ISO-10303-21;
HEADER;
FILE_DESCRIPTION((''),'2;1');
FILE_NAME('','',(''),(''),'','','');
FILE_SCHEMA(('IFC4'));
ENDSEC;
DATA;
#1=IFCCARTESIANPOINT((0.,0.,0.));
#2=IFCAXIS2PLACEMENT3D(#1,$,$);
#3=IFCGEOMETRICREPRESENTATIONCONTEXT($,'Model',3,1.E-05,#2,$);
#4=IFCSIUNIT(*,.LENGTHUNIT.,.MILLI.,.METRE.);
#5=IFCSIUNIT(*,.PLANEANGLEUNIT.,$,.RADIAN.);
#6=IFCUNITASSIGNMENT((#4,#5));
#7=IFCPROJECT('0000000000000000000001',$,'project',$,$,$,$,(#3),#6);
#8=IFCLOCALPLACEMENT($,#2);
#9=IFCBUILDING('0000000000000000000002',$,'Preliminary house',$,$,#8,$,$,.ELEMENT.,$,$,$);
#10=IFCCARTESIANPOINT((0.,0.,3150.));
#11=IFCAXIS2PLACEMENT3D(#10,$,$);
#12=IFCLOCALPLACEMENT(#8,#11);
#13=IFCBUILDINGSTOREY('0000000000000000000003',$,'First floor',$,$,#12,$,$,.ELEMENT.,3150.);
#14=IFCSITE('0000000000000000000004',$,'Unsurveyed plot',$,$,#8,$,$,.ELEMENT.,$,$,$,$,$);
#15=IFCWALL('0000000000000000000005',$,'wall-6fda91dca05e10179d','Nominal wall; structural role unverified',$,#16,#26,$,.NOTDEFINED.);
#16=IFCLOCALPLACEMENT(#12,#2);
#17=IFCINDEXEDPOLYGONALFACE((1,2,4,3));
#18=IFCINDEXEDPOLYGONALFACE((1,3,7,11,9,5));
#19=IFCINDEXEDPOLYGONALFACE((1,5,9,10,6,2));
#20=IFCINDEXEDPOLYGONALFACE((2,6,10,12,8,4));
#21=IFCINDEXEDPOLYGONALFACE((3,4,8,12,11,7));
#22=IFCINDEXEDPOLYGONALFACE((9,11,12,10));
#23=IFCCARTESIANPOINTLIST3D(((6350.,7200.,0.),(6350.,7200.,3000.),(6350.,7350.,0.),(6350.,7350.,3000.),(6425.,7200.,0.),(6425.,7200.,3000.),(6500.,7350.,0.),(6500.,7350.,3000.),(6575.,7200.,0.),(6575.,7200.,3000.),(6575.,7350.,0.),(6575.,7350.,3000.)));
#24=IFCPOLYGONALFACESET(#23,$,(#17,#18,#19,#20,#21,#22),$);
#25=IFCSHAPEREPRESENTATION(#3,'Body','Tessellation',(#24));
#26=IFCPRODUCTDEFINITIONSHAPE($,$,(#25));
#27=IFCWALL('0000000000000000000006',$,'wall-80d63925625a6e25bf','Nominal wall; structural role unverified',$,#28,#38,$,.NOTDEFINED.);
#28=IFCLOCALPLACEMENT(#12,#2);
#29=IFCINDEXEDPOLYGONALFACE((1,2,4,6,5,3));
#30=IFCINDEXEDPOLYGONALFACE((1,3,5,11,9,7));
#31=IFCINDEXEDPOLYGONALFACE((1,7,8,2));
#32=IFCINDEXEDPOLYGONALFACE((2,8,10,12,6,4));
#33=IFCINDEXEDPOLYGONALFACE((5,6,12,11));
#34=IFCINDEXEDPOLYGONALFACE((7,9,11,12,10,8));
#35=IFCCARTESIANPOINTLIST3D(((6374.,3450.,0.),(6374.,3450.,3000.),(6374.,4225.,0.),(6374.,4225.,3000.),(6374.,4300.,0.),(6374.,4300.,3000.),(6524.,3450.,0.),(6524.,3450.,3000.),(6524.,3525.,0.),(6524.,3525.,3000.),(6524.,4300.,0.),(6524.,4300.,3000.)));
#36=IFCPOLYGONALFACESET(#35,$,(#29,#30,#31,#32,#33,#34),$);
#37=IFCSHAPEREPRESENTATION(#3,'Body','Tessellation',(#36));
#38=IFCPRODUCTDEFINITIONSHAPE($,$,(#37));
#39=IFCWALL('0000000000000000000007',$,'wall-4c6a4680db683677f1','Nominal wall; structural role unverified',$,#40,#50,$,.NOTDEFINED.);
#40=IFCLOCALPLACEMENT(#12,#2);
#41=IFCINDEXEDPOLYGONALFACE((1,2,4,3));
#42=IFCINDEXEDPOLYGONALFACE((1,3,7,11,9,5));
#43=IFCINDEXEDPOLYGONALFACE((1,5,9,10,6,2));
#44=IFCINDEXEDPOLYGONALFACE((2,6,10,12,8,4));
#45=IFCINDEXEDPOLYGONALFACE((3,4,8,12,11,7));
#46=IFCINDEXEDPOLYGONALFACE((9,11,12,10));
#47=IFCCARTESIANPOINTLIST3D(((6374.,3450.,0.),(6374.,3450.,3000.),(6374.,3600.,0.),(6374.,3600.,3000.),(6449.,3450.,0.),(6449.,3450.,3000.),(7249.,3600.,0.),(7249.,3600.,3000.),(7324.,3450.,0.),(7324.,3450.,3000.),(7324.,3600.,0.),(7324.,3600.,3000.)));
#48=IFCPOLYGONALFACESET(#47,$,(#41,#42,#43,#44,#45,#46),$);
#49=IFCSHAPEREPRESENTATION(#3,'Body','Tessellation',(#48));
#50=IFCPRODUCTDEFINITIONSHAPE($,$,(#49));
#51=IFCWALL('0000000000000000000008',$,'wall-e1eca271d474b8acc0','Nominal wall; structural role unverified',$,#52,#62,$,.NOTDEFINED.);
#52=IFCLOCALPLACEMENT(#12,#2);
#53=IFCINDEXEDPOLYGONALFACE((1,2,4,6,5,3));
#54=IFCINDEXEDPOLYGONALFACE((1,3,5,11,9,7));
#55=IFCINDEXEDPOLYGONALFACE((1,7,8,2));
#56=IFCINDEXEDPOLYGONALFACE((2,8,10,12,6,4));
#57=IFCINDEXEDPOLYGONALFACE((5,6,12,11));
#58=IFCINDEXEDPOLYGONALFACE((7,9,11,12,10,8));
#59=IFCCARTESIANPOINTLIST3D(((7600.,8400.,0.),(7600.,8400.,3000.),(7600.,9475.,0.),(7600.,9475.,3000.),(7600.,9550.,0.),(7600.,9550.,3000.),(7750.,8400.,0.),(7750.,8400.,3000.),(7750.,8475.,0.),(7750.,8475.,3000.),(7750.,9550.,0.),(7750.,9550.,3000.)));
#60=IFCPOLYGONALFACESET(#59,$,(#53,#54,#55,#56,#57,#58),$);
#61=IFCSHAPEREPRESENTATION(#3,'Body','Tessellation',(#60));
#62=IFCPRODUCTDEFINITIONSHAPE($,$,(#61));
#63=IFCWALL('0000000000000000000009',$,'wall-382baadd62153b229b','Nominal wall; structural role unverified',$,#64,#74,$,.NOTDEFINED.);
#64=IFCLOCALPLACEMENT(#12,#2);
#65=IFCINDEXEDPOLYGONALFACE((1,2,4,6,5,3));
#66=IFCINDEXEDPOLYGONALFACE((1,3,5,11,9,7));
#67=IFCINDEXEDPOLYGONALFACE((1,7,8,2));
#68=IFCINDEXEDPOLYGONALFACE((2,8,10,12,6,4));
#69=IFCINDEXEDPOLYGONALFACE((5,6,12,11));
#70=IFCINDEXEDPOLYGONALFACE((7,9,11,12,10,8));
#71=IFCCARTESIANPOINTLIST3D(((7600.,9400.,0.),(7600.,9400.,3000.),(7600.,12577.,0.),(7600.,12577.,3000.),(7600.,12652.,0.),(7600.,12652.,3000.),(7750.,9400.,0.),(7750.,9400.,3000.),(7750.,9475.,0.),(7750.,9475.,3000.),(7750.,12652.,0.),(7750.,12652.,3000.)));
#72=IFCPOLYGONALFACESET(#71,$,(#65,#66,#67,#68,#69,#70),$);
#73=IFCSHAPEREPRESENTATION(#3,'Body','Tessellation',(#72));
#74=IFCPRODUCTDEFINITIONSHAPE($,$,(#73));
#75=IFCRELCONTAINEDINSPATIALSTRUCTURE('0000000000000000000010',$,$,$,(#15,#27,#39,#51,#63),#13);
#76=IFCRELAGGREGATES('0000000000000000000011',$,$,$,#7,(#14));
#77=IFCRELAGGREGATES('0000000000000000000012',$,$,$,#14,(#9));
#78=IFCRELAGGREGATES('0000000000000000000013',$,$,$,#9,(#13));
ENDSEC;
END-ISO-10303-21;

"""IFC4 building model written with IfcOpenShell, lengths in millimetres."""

from ifc_helpers import new_model, si_unit, frame, origin, place, context, project, spatial, polyline, outline, extrude, element, save


model = new_model("IFC4")

# Units and contexts
model_context = context("Model", 3, precision=1e-05, world=origin())
ifc_project = project(units=[si_unit("LENGTHUNIT", "METRE", prefix="MILLI"), si_unit("PLANEANGLEUNIT", "RADIAN")], contexts=[model_context])

# Site, building, storey
placement_1 = place(None, origin())
site = spatial("IfcSite", under=ifc_project, at=placement_1, Name="Unsurveyed plot", CompositionType="ELEMENT")
building = spatial("IfcBuilding", under=site, at=placement_1, Name="Preliminary house", CompositionType="ELEMENT")
placement_2 = place(placement_1, frame((0.0, 0.0, 3150.0)))
storey = spatial("IfcBuildingStorey", under=building, at=placement_2, Name="First floor", CompositionType="ELEMENT", Elevation=3150.0)

# Walls
element("IfcWall", 1, at=placement_2, inside=storey, Name="wall-6fda91dca05e10179d", Description="Nominal wall; structural role unverified", PredefinedType="NOTDEFINED", context=model_context, shape_type="SweptSolid", body=[
    extrude(outline(polyline([(6500.0, 7350.0), (6575.0, 7350.0), (6575.0, 7200.0), (6425.0, 7200.0), (6350.0, 7200.0), (6350.0, 7350.0), (6500.0, 7350.0)])), origin(), (0.0, 0.0, 1.0), 3000.0),
])
element("IfcWall", 2, at=placement_2, inside=storey, Name="wall-80d63925625a6e25bf", Description="Nominal wall; structural role unverified", PredefinedType="NOTDEFINED", context=model_context, shape_type="SweptSolid", body=[
    extrude(outline(polyline([(6374.0, 4225.0), (6374.0, 4300.0), (6524.0, 4300.0), (6524.0, 3525.0), (6524.0, 3450.0), (6374.0, 3450.0), (6374.0, 4225.0)])), origin(), (0.0, 0.0, 1.0), 3000.0),
])
element("IfcWall", 3, at=placement_2, inside=storey, Name="wall-4c6a4680db683677f1", Description="Nominal wall; structural role unverified", PredefinedType="NOTDEFINED", context=model_context, shape_type="SweptSolid", body=[
    extrude(outline(polyline([(7249.0, 3600.0), (7324.0, 3600.0), (7324.0, 3450.0), (6449.0, 3450.0), (6374.0, 3450.0), (6374.0, 3600.0), (7249.0, 3600.0)])), origin(), (0.0, 0.0, 1.0), 3000.0),
])

# Walls
element("IfcWall", 4, at=placement_2, inside=storey, Name="wall-e1eca271d474b8acc0", Description="Nominal wall; structural role unverified", PredefinedType="NOTDEFINED", context=model_context, shape_type="SweptSolid", body=[
    extrude(outline(polyline([(7600.0, 9475.0), (7600.0, 9550.0), (7750.0, 9550.0), (7750.0, 8475.0), (7750.0, 8400.0), (7600.0, 8400.0), (7600.0, 9475.0)])), origin(), (0.0, 0.0, 1.0), 3000.0),
])
element("IfcWall", 5, at=placement_2, inside=storey, Name="wall-382baadd62153b229b", Description="Nominal wall; structural role unverified", PredefinedType="NOTDEFINED", context=model_context, shape_type="SweptSolid", body=[
    extrude(outline(polyline([(7600.0, 12577.0), (7600.0, 12652.0), (7750.0, 12652.0), (7750.0, 9475.0), (7750.0, 9400.0), (7600.0, 9400.0), (7600.0, 12577.0)])), origin(), (0.0, 0.0, 1.0), 3000.0),
])

save(model, "model.ifc")
